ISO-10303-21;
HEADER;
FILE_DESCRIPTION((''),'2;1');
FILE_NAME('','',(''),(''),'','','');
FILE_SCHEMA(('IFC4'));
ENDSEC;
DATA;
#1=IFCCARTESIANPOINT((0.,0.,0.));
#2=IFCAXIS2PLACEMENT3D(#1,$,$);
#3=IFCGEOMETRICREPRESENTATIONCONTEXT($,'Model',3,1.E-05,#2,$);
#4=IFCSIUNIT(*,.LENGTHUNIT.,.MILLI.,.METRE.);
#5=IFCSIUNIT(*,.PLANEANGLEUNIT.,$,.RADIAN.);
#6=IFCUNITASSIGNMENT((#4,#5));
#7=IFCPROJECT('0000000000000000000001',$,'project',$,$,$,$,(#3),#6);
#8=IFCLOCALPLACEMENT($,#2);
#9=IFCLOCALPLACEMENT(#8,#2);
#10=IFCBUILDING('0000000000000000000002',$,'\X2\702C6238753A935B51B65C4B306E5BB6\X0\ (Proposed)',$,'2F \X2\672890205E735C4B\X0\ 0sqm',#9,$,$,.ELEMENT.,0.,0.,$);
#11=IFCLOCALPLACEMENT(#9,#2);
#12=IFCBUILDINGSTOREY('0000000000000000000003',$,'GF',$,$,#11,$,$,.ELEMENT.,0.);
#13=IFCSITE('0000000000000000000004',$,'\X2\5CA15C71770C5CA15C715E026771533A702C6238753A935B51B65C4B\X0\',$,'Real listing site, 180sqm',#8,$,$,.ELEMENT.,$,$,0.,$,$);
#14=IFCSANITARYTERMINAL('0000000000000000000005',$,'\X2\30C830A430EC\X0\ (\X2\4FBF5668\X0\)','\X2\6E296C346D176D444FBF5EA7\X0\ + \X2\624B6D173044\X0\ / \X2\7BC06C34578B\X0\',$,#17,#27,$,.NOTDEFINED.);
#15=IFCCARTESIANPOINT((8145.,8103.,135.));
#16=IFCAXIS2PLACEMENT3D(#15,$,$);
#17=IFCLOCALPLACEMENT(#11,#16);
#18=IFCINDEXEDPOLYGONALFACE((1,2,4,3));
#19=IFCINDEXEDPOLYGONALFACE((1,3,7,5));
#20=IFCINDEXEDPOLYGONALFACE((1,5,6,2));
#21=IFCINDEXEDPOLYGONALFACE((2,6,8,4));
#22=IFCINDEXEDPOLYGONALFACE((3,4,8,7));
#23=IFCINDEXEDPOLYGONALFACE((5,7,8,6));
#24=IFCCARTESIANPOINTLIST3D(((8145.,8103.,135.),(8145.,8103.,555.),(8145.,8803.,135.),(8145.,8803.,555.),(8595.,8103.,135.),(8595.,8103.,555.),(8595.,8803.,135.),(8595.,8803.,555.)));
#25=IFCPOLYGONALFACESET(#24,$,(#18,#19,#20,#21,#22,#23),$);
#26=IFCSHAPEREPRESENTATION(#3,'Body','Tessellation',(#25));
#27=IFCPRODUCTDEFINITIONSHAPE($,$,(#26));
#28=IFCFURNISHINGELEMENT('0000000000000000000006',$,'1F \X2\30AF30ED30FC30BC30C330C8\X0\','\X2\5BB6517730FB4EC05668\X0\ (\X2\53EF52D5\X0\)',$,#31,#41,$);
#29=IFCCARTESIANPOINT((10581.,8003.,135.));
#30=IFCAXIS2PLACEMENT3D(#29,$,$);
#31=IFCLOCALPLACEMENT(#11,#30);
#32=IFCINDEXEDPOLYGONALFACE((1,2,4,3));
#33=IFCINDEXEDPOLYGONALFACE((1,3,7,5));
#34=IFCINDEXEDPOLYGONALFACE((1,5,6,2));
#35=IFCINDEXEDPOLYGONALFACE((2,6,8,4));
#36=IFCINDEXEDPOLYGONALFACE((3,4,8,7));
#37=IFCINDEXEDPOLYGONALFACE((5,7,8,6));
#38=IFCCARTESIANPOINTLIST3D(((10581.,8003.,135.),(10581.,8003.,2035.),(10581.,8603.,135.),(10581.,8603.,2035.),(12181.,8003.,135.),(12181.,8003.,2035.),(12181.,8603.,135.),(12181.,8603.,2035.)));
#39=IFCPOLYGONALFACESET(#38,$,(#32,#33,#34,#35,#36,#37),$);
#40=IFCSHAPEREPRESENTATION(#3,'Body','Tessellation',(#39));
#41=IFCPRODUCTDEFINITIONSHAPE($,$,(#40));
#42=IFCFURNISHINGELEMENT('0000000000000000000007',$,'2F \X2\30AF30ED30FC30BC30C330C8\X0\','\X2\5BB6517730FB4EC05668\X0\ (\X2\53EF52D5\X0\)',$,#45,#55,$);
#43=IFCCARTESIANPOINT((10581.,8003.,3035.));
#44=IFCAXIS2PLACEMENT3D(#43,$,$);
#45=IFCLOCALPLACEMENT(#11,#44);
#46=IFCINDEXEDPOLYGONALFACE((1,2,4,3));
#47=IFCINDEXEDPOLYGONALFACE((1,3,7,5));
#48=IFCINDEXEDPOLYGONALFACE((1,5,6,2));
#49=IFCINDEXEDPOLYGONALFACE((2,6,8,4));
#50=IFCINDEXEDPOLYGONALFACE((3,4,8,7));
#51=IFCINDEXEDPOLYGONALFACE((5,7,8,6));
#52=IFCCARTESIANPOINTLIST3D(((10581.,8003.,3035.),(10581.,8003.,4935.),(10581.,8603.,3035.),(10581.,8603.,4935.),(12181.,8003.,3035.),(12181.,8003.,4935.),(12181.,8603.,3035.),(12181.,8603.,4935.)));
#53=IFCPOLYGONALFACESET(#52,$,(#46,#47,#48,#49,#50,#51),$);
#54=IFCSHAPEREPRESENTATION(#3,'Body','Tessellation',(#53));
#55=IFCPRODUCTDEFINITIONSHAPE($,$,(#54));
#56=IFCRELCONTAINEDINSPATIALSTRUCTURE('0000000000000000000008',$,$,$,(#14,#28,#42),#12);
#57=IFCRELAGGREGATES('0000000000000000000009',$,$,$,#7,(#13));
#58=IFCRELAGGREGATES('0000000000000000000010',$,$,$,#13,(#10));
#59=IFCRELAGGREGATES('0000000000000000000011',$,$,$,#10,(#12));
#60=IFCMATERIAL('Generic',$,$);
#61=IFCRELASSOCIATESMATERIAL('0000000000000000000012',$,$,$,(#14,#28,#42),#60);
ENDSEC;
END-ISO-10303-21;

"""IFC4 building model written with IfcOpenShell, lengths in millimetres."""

from ifc_helpers import new_model, si_unit, frame, frame_2d, origin, place, context, project, spatial, rectangle, extrude, material, element, save


model = new_model("IFC4")

# Units and contexts
model_context = context("Model", 3, precision=1e-05, world=origin())
ifc_project = project(units=[si_unit("LENGTHUNIT", "METRE", prefix="MILLI"), si_unit("PLANEANGLEUNIT", "RADIAN")], contexts=[model_context])

# Site, building, storey
site_placement = place(None, origin())
site = spatial("IfcSite", under=ifc_project, at=site_placement, Name="岡山県岡山市東区瀬戸町鍛冶屋", ObjectType="Real listing site, 180sqm", CompositionType="ELEMENT", RefElevation=0.0)
building_placement = place(site_placement, origin())
building = spatial("IfcBuilding", under=site, at=building_placement, Name="瀬戸町鍛冶屋の家 (Proposed)", ObjectType="2F 木造平屋 0sqm", CompositionType="ELEMENT", ElevationOfRefHeight=0.0, ElevationOfTerrain=0.0)
storey_placement = place(building_placement, origin())
storey = spatial("IfcBuildingStorey", under=building, at=storey_placement, Name="GF", CompositionType="ELEMENT", Elevation=0.0)

# Shared definitions
ifc_material_1 = material(Name="Generic")

# Sanitary terminal
sanitary_terminal_1_placement = place(storey_placement, frame((8145.0, 8103.0, 135.0)))
element("IfcSanitaryTerminal", 1, at=sanitary_terminal_1_placement, inside=storey, material=ifc_material_1, Name="トイレ (便器)", Description="温水洗浄便座 + 手洗い / 節水型", PredefinedType="NOTDEFINED", context=model_context, shape_type="SweptSolid", body=[
    extrude(rectangle(XDim=450.0, YDim=700.0, at=frame_2d((225.0, 350.0))), frame((8145.0, 8103.0, 135.0)), (0.0, 0.0, 1.0), 420.0),
])

# Furnishing elements
furnishing_1_placement = place(storey_placement, frame((10581.0, 8003.0, 135.0)))
element("IfcFurnishingElement", 2, at=furnishing_1_placement, inside=storey, material=ifc_material_1, Name="1F クローゼット", Description="家具・什器 (可動)", context=model_context, shape_type="SweptSolid", body=[
    extrude(rectangle(XDim=1600.0, YDim=600.0, at=frame_2d((800.0, 300.0))), frame((10581.0, 8003.0, 135.0)), (0.0, 0.0, 1.0), 1900.0),
])
furnishing_2_placement = place(storey_placement, frame((10581.0, 8003.0, 3035.0)))
element("IfcFurnishingElement", 3, at=furnishing_2_placement, inside=storey, material=ifc_material_1, Name="2F クローゼット", Description="家具・什器 (可動)", context=model_context, shape_type="SweptSolid", body=[
    extrude(rectangle(XDim=1600.0, YDim=600.0, at=frame_2d((800.0, 300.0))), frame((10581.0, 8003.0, 3035.0)), (0.0, 0.0, 1.0), 1900.0),
])

save(model, "model.ifc")
